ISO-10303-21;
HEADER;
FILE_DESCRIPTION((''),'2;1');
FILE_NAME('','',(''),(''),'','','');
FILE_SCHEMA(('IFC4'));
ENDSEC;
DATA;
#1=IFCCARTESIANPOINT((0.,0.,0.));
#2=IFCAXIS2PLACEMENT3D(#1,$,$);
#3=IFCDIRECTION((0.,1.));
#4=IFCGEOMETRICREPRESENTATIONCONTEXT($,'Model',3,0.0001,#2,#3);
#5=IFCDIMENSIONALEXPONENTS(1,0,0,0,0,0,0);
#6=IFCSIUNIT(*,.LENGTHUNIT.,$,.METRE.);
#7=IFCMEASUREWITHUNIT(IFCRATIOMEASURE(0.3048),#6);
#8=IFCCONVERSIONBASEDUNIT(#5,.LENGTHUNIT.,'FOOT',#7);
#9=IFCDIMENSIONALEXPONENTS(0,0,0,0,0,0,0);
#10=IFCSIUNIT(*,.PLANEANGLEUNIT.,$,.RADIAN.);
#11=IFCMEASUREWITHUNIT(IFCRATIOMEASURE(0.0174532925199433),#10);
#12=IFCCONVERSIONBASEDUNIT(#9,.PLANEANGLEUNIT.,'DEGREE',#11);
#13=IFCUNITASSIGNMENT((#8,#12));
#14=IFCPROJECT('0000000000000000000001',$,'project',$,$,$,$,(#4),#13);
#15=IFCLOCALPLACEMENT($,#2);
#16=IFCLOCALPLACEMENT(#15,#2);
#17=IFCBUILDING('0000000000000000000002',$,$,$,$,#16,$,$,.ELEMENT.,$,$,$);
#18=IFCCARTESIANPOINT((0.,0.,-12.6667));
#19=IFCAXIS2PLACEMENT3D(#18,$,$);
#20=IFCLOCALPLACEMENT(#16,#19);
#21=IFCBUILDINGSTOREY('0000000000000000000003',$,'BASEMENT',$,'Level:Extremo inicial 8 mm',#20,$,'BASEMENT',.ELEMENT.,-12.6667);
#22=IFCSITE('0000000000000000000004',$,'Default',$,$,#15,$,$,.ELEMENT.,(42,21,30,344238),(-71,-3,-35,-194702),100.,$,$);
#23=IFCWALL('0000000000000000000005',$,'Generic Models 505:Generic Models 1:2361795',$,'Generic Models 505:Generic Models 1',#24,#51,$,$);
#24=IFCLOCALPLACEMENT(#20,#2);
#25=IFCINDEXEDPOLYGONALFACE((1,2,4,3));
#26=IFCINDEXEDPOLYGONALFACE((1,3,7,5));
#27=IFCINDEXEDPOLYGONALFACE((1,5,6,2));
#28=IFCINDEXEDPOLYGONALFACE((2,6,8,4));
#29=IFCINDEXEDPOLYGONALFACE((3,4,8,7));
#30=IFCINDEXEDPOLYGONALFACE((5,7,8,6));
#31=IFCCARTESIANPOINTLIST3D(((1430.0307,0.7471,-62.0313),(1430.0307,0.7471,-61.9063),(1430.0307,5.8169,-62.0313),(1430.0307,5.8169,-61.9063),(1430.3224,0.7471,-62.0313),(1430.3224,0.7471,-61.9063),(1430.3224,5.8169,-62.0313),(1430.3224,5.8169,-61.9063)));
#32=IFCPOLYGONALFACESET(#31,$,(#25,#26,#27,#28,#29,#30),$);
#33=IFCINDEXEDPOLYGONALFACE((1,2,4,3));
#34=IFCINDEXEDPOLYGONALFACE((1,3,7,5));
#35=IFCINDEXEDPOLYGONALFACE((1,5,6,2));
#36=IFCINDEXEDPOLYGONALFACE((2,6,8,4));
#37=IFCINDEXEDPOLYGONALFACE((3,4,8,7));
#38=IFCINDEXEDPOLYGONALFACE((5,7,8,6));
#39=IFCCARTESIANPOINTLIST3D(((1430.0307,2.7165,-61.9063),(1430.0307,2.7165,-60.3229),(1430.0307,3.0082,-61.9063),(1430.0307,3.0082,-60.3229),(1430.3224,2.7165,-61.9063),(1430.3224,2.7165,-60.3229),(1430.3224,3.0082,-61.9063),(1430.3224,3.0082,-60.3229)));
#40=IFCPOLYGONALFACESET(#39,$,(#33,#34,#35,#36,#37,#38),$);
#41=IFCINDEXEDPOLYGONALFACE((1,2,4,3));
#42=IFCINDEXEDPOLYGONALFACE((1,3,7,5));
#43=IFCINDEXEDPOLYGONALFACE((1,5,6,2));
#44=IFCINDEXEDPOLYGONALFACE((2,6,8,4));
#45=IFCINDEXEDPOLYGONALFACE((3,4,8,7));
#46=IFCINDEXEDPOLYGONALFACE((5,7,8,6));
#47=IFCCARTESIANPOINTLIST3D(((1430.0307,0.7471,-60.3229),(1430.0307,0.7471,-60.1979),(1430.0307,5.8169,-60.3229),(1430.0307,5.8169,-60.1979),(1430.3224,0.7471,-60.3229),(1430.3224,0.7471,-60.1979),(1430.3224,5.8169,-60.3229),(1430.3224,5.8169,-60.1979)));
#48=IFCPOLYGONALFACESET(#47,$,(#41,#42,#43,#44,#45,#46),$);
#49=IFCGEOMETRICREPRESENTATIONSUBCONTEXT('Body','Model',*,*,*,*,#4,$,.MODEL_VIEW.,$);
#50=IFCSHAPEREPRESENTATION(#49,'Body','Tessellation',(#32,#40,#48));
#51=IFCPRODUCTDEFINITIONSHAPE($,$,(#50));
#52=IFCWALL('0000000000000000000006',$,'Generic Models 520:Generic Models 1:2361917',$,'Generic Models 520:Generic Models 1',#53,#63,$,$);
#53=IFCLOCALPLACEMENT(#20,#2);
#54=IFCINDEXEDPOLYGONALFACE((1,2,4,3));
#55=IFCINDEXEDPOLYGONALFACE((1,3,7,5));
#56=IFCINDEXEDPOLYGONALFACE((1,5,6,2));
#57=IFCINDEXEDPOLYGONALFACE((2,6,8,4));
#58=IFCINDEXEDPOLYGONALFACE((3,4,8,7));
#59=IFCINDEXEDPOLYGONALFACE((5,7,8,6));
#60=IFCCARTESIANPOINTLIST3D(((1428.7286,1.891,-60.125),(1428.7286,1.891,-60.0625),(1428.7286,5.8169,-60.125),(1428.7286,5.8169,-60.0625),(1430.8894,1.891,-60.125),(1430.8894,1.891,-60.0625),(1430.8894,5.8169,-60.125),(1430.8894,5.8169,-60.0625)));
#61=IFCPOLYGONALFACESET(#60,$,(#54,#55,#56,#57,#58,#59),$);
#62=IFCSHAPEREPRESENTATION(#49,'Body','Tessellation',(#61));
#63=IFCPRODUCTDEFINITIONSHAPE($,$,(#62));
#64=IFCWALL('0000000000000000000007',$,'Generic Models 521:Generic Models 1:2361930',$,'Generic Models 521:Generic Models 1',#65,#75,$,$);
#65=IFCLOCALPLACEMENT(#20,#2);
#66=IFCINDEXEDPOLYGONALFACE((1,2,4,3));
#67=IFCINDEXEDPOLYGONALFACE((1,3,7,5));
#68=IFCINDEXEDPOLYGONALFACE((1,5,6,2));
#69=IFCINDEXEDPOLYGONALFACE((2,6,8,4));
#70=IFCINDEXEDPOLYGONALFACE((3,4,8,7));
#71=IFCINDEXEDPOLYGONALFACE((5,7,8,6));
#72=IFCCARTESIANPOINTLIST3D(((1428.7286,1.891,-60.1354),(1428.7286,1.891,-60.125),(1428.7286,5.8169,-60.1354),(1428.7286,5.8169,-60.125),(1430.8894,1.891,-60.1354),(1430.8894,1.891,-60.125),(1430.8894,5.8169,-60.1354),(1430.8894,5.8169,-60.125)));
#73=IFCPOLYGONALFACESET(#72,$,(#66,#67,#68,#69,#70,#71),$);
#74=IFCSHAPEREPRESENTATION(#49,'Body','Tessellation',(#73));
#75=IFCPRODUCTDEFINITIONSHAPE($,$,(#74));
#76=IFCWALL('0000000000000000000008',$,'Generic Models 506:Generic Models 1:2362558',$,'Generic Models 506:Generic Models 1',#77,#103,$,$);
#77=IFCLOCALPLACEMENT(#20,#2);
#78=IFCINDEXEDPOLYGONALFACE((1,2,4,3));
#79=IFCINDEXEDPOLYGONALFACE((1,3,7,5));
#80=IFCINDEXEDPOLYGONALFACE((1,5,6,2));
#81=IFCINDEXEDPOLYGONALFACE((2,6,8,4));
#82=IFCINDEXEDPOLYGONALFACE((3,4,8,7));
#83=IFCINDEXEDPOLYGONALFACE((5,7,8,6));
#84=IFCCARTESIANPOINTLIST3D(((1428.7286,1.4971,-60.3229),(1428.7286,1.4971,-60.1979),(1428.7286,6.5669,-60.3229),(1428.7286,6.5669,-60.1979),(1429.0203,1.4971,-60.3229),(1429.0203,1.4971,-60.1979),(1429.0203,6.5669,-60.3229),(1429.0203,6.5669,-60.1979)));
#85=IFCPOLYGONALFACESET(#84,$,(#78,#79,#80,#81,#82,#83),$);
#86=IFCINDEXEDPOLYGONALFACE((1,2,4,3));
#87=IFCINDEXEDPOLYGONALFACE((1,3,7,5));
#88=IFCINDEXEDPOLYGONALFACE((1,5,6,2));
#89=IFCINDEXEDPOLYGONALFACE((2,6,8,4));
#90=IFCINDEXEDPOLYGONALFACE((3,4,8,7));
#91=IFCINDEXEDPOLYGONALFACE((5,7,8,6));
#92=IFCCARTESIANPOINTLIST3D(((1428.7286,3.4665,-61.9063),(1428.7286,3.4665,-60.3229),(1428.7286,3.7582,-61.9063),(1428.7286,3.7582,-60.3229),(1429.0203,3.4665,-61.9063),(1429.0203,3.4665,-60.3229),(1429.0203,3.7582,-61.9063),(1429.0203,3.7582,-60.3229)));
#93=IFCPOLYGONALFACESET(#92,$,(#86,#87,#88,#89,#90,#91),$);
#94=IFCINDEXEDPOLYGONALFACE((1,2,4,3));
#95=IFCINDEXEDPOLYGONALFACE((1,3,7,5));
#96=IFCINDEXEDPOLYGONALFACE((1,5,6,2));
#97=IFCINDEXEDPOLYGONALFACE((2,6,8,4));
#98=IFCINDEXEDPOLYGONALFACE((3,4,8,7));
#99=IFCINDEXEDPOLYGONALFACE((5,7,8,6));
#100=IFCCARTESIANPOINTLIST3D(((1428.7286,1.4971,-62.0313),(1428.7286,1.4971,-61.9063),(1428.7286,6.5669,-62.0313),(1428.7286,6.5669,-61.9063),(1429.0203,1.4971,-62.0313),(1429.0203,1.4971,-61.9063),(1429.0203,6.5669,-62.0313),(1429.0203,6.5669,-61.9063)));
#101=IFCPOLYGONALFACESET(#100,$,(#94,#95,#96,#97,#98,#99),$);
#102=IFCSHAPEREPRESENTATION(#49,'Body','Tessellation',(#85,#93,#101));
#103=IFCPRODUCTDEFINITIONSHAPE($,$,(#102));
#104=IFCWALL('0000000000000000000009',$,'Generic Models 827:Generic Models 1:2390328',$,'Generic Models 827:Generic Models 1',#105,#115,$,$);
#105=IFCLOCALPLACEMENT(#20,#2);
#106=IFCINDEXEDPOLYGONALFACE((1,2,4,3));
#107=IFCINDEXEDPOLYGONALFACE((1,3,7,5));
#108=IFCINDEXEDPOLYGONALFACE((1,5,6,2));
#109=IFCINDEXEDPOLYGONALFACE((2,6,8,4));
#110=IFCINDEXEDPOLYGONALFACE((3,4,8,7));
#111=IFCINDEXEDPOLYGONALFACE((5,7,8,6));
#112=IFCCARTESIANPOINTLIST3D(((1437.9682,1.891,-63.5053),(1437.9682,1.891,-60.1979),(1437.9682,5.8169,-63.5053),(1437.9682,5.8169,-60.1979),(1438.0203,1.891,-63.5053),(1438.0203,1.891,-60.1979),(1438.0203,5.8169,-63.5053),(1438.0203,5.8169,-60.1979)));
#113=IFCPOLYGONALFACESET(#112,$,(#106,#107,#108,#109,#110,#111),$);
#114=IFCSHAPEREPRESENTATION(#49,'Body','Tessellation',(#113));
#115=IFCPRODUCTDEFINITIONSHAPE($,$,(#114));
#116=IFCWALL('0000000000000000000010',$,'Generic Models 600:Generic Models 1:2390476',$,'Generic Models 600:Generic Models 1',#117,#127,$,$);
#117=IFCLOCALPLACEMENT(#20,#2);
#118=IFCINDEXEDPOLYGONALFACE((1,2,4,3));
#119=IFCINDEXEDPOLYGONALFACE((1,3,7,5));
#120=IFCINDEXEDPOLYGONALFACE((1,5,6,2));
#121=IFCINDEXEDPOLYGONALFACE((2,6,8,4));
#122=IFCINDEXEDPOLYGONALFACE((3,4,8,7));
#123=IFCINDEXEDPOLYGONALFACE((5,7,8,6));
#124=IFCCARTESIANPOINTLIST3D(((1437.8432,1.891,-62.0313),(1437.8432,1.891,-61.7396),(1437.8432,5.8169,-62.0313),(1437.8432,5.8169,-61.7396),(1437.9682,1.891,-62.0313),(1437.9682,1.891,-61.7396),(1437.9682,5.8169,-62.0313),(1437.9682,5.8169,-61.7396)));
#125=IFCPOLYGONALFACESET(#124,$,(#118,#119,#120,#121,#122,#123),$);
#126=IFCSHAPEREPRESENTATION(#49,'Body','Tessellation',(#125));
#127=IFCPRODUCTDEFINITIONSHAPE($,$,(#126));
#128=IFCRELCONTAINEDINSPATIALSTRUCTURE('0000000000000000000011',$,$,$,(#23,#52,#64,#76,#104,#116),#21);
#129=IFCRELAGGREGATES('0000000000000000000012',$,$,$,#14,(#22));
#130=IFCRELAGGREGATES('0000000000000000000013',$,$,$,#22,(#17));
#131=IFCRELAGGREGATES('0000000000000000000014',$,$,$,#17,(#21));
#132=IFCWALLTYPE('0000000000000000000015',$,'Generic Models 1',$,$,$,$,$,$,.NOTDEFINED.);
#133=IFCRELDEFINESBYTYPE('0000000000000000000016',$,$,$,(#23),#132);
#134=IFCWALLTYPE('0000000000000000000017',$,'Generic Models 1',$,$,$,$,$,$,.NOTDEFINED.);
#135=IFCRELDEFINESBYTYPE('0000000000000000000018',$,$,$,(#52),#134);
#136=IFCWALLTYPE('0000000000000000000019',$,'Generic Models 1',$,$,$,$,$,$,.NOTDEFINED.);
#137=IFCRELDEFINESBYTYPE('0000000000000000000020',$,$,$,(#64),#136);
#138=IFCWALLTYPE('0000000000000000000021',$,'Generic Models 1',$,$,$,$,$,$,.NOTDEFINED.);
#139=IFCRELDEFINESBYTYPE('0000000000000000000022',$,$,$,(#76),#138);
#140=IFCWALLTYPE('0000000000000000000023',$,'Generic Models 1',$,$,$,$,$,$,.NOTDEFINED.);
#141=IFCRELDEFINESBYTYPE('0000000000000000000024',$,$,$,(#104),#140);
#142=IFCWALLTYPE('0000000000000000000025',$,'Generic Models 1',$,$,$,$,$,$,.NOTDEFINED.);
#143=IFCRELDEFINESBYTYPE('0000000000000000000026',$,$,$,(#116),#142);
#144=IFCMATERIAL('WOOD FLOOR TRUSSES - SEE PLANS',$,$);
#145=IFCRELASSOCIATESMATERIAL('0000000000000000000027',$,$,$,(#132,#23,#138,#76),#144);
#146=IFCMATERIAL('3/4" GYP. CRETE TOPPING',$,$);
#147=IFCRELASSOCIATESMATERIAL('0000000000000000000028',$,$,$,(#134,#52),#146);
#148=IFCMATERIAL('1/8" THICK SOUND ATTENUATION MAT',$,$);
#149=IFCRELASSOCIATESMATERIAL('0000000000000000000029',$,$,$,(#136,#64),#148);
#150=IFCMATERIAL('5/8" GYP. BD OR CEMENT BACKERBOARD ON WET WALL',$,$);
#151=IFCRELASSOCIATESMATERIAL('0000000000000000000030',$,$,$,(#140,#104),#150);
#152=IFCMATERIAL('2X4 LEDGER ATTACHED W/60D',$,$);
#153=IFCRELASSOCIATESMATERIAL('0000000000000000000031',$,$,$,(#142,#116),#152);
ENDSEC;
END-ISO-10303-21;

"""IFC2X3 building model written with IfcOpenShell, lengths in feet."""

from ifc_helpers import new_model, entity, si_unit, converted_unit, direction, frame, frame_2d, origin, origin_2d_with_axis, place, context, subcontext, project, spatial, rectangle, extrude, material, type_object, element, save


model = new_model("IFC2X3")

# Units and contexts
model_context = context("Model", 3, precision=0.0001, world=origin(), true_north=direction((0.0, 1.0)))
body_context = subcontext(model_context, "Body", "Model", "MODEL_VIEW")
ifc_project = project(units=[converted_unit("LENGTHUNIT", "FOOT", entity("IfcRatioMeasure", 0.3048), si_unit("LENGTHUNIT", "METRE"), dimensions=[1, 0, 0, 0, 0, 0, 0]), converted_unit("PLANEANGLEUNIT", "DEGREE", entity("IfcRatioMeasure", 0.0174532925199433), si_unit("PLANEANGLEUNIT", "RADIAN"), dimensions=[0, 0, 0, 0, 0, 0, 0])], contexts=[model_context])

# Site, building, storey
site_placement = place(None, origin())
site = spatial("IfcSite", under=ifc_project, at=site_placement, Name="Default", CompositionType="ELEMENT", RefLatitude=(42, 21, 30, 344238), RefLongitude=(-71, -3, -35, -194702), RefElevation=100.0)
building_placement = place(site_placement, origin())
building = spatial("IfcBuilding", under=site, at=building_placement, CompositionType="ELEMENT")
storey_placement = place(building_placement, frame((0.0, 0.0, -12.6667)))
storey = spatial("IfcBuildingStorey", under=building, at=storey_placement, Name="BASEMENT", ObjectType="Level:Extremo inicial 8 mm", LongName="BASEMENT", CompositionType="ELEMENT", Elevation=-12.6667)

# Walls
ifc_material_1 = material(Name="WOOD FLOOR TRUSSES - SEE PLANS")
ifc_material_2 = material(Name="3/4\" GYP. CRETE TOPPING")
ifc_material_3 = material(Name="1/8\" THICK SOUND ATTENUATION MAT")
ifc_material_4 = material(Name="5/8\" GYP. BD OR CEMENT BACKERBOARD ON WET WALL")
wall_type_1 = type_object("IfcWallType", Name="Generic Models 1", PredefinedType="NOTDEFINED", material=ifc_material_1)
wall_1_placement = place(storey_placement, frame((1430.0307, 0.7471, -62.0313), z_axis=(0.0, 0.0, 1.0), x_axis=(0.0, 1.0, 0.0)))
element("IfcWall", 1, at=wall_1_placement, inside=storey, type_object=wall_type_1, material=ifc_material_1, Name="Generic Models 505:Generic Models 1:2361795", ObjectType="Generic Models 505:Generic Models 1", context=body_context, shape_type="SweptSolid", body=[
    extrude(rectangle(XDim=5.0697, YDim=0.2917, at=frame_2d((0.0, 0.0), x_axis=(1.0, 0.0))), frame((2.5349, -0.1458, 0.0)), (0.0, 0.0, 1.0), 0.125),
    extrude(rectangle(XDim=0.2917, YDim=0.2917, at=frame_2d((0.0, 0.0), x_axis=(1.0, 0.0))), frame((2.1152, -0.1458, 0.125)), (0.0, 0.0, 1.0), 1.5833),
    extrude(rectangle(XDim=5.0697, YDim=0.2917, at=frame_2d((0.0, 0.0), x_axis=(1.0, 0.0))), frame((2.5349, -0.1458, 1.7083)), (0.0, 0.0, 1.0), 0.125),
])
wall_type_2 = type_object("IfcWallType", Name="Generic Models 1", PredefinedType="NOTDEFINED", material=ifc_material_2)
wall_2_placement = place(storey_placement, frame((1428.7286, 1.891, -60.125), z_axis=(0.0, 0.0, 1.0), x_axis=(0.0, 1.0, 0.0)))
element("IfcWall", 2, at=wall_2_placement, inside=storey, type_object=wall_type_2, material=ifc_material_2, Name="Generic Models 520:Generic Models 1:2361917", ObjectType="Generic Models 520:Generic Models 1", context=body_context, shape_type="SweptSolid", body=[
    extrude(rectangle(XDim=3.9258, YDim=2.1608, at=origin_2d_with_axis()), frame((1.9629, -1.0804, 0.0)), (0.0, 0.0, 1.0), 0.0625),
])
wall_type_3 = type_object("IfcWallType", Name="Generic Models 1", PredefinedType="NOTDEFINED", material=ifc_material_3)
wall_3_placement = place(storey_placement, frame((1428.7286, 1.891, -60.1354), z_axis=(0.0, 0.0, 1.0), x_axis=(0.0, 1.0, 0.0)))
element("IfcWall", 3, at=wall_3_placement, inside=storey, type_object=wall_type_3, material=ifc_material_3, Name="Generic Models 521:Generic Models 1:2361930", ObjectType="Generic Models 521:Generic Models 1", context=body_context, shape_type="SweptSolid", body=[
    extrude(rectangle(XDim=3.9258, YDim=2.1608, at=origin_2d_with_axis()), frame((1.9629, -1.0804, 0.0)), (0.0, 0.0, 1.0), 0.0104),
])
wall_type_4 = type_object("IfcWallType", Name="Generic Models 1", PredefinedType="NOTDEFINED", material=ifc_material_1)
wall_4_placement = place(storey_placement, frame((1428.7286, 1.4971, -62.0313), z_axis=(0.0, 0.0, 1.0), x_axis=(0.0, 1.0, 0.0)))
element("IfcWall", 4, at=wall_4_placement, inside=storey, type_object=wall_type_4, material=ifc_material_1, Name="Generic Models 506:Generic Models 1:2362558", ObjectType="Generic Models 506:Generic Models 1", context=body_context, shape_type="SweptSolid", body=[
    extrude(rectangle(XDim=5.0697, YDim=0.2917, at=frame_2d((0.0, 0.0), x_axis=(1.0, 0.0))), frame((2.5349, -0.1458, 1.7083)), (0.0, 0.0, 1.0), 0.125),
    extrude(rectangle(XDim=0.2917, YDim=0.2917, at=frame_2d((0.0, 0.0), x_axis=(1.0, 0.0))), frame((2.1152, -0.1458, 0.125)), (0.0, 0.0, 1.0), 1.5833),
    extrude(rectangle(XDim=5.0697, YDim=0.2917, at=frame_2d((0.0, 0.0), x_axis=(1.0, 0.0))), frame((2.5349, -0.1458, 0.0)), (0.0, 0.0, 1.0), 0.125),
])
wall_type_5 = type_object("IfcWallType", Name="Generic Models 1", PredefinedType="NOTDEFINED", material=ifc_material_4)
wall_5_placement = place(storey_placement, frame((1437.9682, 1.891, -63.5053), z_axis=(0.0, 0.0, 1.0), x_axis=(0.0, 1.0, 0.0)))
element("IfcWall", 5, at=wall_5_placement, inside=storey, type_object=wall_type_5, material=ifc_material_4, Name="Generic Models 827:Generic Models 1:2390328", ObjectType="Generic Models 827:Generic Models 1", context=body_context, shape_type="SweptSolid", body=[
    extrude(rectangle(XDim=3.9258, YDim=0.0521, at=frame_2d((0.0, 0.0), x_axis=(1.0, 0.0))), frame((1.9629, -0.026, 0.0)), (0.0, 0.0, 1.0), 3.3074),
])
ifc_material_5 = material(Name="2X4 LEDGER ATTACHED W/60D")
wall_type_6 = type_object("IfcWallType", Name="Generic Models 1", PredefinedType="NOTDEFINED", material=ifc_material_5)
wall_6_placement = place(storey_placement, frame((1437.8432, 1.891, -62.0313), z_axis=(0.0, 0.0, 1.0), x_axis=(0.0, 1.0, 0.0)))
element("IfcWall", 6, at=wall_6_placement, inside=storey, type_object=wall_type_6, material=ifc_material_5, Name="Generic Models 600:Generic Models 1:2390476", ObjectType="Generic Models 600:Generic Models 1", context=body_context, shape_type="SweptSolid", body=[
    extrude(rectangle(XDim=3.9258, YDim=0.125, at=frame_2d((0.0, 0.0), x_axis=(1.0, 0.0))), frame((1.9629, -0.0625, 0.0)), (0.0, 0.0, 1.0), 0.2917),
])

save(model, "model.ifc")
